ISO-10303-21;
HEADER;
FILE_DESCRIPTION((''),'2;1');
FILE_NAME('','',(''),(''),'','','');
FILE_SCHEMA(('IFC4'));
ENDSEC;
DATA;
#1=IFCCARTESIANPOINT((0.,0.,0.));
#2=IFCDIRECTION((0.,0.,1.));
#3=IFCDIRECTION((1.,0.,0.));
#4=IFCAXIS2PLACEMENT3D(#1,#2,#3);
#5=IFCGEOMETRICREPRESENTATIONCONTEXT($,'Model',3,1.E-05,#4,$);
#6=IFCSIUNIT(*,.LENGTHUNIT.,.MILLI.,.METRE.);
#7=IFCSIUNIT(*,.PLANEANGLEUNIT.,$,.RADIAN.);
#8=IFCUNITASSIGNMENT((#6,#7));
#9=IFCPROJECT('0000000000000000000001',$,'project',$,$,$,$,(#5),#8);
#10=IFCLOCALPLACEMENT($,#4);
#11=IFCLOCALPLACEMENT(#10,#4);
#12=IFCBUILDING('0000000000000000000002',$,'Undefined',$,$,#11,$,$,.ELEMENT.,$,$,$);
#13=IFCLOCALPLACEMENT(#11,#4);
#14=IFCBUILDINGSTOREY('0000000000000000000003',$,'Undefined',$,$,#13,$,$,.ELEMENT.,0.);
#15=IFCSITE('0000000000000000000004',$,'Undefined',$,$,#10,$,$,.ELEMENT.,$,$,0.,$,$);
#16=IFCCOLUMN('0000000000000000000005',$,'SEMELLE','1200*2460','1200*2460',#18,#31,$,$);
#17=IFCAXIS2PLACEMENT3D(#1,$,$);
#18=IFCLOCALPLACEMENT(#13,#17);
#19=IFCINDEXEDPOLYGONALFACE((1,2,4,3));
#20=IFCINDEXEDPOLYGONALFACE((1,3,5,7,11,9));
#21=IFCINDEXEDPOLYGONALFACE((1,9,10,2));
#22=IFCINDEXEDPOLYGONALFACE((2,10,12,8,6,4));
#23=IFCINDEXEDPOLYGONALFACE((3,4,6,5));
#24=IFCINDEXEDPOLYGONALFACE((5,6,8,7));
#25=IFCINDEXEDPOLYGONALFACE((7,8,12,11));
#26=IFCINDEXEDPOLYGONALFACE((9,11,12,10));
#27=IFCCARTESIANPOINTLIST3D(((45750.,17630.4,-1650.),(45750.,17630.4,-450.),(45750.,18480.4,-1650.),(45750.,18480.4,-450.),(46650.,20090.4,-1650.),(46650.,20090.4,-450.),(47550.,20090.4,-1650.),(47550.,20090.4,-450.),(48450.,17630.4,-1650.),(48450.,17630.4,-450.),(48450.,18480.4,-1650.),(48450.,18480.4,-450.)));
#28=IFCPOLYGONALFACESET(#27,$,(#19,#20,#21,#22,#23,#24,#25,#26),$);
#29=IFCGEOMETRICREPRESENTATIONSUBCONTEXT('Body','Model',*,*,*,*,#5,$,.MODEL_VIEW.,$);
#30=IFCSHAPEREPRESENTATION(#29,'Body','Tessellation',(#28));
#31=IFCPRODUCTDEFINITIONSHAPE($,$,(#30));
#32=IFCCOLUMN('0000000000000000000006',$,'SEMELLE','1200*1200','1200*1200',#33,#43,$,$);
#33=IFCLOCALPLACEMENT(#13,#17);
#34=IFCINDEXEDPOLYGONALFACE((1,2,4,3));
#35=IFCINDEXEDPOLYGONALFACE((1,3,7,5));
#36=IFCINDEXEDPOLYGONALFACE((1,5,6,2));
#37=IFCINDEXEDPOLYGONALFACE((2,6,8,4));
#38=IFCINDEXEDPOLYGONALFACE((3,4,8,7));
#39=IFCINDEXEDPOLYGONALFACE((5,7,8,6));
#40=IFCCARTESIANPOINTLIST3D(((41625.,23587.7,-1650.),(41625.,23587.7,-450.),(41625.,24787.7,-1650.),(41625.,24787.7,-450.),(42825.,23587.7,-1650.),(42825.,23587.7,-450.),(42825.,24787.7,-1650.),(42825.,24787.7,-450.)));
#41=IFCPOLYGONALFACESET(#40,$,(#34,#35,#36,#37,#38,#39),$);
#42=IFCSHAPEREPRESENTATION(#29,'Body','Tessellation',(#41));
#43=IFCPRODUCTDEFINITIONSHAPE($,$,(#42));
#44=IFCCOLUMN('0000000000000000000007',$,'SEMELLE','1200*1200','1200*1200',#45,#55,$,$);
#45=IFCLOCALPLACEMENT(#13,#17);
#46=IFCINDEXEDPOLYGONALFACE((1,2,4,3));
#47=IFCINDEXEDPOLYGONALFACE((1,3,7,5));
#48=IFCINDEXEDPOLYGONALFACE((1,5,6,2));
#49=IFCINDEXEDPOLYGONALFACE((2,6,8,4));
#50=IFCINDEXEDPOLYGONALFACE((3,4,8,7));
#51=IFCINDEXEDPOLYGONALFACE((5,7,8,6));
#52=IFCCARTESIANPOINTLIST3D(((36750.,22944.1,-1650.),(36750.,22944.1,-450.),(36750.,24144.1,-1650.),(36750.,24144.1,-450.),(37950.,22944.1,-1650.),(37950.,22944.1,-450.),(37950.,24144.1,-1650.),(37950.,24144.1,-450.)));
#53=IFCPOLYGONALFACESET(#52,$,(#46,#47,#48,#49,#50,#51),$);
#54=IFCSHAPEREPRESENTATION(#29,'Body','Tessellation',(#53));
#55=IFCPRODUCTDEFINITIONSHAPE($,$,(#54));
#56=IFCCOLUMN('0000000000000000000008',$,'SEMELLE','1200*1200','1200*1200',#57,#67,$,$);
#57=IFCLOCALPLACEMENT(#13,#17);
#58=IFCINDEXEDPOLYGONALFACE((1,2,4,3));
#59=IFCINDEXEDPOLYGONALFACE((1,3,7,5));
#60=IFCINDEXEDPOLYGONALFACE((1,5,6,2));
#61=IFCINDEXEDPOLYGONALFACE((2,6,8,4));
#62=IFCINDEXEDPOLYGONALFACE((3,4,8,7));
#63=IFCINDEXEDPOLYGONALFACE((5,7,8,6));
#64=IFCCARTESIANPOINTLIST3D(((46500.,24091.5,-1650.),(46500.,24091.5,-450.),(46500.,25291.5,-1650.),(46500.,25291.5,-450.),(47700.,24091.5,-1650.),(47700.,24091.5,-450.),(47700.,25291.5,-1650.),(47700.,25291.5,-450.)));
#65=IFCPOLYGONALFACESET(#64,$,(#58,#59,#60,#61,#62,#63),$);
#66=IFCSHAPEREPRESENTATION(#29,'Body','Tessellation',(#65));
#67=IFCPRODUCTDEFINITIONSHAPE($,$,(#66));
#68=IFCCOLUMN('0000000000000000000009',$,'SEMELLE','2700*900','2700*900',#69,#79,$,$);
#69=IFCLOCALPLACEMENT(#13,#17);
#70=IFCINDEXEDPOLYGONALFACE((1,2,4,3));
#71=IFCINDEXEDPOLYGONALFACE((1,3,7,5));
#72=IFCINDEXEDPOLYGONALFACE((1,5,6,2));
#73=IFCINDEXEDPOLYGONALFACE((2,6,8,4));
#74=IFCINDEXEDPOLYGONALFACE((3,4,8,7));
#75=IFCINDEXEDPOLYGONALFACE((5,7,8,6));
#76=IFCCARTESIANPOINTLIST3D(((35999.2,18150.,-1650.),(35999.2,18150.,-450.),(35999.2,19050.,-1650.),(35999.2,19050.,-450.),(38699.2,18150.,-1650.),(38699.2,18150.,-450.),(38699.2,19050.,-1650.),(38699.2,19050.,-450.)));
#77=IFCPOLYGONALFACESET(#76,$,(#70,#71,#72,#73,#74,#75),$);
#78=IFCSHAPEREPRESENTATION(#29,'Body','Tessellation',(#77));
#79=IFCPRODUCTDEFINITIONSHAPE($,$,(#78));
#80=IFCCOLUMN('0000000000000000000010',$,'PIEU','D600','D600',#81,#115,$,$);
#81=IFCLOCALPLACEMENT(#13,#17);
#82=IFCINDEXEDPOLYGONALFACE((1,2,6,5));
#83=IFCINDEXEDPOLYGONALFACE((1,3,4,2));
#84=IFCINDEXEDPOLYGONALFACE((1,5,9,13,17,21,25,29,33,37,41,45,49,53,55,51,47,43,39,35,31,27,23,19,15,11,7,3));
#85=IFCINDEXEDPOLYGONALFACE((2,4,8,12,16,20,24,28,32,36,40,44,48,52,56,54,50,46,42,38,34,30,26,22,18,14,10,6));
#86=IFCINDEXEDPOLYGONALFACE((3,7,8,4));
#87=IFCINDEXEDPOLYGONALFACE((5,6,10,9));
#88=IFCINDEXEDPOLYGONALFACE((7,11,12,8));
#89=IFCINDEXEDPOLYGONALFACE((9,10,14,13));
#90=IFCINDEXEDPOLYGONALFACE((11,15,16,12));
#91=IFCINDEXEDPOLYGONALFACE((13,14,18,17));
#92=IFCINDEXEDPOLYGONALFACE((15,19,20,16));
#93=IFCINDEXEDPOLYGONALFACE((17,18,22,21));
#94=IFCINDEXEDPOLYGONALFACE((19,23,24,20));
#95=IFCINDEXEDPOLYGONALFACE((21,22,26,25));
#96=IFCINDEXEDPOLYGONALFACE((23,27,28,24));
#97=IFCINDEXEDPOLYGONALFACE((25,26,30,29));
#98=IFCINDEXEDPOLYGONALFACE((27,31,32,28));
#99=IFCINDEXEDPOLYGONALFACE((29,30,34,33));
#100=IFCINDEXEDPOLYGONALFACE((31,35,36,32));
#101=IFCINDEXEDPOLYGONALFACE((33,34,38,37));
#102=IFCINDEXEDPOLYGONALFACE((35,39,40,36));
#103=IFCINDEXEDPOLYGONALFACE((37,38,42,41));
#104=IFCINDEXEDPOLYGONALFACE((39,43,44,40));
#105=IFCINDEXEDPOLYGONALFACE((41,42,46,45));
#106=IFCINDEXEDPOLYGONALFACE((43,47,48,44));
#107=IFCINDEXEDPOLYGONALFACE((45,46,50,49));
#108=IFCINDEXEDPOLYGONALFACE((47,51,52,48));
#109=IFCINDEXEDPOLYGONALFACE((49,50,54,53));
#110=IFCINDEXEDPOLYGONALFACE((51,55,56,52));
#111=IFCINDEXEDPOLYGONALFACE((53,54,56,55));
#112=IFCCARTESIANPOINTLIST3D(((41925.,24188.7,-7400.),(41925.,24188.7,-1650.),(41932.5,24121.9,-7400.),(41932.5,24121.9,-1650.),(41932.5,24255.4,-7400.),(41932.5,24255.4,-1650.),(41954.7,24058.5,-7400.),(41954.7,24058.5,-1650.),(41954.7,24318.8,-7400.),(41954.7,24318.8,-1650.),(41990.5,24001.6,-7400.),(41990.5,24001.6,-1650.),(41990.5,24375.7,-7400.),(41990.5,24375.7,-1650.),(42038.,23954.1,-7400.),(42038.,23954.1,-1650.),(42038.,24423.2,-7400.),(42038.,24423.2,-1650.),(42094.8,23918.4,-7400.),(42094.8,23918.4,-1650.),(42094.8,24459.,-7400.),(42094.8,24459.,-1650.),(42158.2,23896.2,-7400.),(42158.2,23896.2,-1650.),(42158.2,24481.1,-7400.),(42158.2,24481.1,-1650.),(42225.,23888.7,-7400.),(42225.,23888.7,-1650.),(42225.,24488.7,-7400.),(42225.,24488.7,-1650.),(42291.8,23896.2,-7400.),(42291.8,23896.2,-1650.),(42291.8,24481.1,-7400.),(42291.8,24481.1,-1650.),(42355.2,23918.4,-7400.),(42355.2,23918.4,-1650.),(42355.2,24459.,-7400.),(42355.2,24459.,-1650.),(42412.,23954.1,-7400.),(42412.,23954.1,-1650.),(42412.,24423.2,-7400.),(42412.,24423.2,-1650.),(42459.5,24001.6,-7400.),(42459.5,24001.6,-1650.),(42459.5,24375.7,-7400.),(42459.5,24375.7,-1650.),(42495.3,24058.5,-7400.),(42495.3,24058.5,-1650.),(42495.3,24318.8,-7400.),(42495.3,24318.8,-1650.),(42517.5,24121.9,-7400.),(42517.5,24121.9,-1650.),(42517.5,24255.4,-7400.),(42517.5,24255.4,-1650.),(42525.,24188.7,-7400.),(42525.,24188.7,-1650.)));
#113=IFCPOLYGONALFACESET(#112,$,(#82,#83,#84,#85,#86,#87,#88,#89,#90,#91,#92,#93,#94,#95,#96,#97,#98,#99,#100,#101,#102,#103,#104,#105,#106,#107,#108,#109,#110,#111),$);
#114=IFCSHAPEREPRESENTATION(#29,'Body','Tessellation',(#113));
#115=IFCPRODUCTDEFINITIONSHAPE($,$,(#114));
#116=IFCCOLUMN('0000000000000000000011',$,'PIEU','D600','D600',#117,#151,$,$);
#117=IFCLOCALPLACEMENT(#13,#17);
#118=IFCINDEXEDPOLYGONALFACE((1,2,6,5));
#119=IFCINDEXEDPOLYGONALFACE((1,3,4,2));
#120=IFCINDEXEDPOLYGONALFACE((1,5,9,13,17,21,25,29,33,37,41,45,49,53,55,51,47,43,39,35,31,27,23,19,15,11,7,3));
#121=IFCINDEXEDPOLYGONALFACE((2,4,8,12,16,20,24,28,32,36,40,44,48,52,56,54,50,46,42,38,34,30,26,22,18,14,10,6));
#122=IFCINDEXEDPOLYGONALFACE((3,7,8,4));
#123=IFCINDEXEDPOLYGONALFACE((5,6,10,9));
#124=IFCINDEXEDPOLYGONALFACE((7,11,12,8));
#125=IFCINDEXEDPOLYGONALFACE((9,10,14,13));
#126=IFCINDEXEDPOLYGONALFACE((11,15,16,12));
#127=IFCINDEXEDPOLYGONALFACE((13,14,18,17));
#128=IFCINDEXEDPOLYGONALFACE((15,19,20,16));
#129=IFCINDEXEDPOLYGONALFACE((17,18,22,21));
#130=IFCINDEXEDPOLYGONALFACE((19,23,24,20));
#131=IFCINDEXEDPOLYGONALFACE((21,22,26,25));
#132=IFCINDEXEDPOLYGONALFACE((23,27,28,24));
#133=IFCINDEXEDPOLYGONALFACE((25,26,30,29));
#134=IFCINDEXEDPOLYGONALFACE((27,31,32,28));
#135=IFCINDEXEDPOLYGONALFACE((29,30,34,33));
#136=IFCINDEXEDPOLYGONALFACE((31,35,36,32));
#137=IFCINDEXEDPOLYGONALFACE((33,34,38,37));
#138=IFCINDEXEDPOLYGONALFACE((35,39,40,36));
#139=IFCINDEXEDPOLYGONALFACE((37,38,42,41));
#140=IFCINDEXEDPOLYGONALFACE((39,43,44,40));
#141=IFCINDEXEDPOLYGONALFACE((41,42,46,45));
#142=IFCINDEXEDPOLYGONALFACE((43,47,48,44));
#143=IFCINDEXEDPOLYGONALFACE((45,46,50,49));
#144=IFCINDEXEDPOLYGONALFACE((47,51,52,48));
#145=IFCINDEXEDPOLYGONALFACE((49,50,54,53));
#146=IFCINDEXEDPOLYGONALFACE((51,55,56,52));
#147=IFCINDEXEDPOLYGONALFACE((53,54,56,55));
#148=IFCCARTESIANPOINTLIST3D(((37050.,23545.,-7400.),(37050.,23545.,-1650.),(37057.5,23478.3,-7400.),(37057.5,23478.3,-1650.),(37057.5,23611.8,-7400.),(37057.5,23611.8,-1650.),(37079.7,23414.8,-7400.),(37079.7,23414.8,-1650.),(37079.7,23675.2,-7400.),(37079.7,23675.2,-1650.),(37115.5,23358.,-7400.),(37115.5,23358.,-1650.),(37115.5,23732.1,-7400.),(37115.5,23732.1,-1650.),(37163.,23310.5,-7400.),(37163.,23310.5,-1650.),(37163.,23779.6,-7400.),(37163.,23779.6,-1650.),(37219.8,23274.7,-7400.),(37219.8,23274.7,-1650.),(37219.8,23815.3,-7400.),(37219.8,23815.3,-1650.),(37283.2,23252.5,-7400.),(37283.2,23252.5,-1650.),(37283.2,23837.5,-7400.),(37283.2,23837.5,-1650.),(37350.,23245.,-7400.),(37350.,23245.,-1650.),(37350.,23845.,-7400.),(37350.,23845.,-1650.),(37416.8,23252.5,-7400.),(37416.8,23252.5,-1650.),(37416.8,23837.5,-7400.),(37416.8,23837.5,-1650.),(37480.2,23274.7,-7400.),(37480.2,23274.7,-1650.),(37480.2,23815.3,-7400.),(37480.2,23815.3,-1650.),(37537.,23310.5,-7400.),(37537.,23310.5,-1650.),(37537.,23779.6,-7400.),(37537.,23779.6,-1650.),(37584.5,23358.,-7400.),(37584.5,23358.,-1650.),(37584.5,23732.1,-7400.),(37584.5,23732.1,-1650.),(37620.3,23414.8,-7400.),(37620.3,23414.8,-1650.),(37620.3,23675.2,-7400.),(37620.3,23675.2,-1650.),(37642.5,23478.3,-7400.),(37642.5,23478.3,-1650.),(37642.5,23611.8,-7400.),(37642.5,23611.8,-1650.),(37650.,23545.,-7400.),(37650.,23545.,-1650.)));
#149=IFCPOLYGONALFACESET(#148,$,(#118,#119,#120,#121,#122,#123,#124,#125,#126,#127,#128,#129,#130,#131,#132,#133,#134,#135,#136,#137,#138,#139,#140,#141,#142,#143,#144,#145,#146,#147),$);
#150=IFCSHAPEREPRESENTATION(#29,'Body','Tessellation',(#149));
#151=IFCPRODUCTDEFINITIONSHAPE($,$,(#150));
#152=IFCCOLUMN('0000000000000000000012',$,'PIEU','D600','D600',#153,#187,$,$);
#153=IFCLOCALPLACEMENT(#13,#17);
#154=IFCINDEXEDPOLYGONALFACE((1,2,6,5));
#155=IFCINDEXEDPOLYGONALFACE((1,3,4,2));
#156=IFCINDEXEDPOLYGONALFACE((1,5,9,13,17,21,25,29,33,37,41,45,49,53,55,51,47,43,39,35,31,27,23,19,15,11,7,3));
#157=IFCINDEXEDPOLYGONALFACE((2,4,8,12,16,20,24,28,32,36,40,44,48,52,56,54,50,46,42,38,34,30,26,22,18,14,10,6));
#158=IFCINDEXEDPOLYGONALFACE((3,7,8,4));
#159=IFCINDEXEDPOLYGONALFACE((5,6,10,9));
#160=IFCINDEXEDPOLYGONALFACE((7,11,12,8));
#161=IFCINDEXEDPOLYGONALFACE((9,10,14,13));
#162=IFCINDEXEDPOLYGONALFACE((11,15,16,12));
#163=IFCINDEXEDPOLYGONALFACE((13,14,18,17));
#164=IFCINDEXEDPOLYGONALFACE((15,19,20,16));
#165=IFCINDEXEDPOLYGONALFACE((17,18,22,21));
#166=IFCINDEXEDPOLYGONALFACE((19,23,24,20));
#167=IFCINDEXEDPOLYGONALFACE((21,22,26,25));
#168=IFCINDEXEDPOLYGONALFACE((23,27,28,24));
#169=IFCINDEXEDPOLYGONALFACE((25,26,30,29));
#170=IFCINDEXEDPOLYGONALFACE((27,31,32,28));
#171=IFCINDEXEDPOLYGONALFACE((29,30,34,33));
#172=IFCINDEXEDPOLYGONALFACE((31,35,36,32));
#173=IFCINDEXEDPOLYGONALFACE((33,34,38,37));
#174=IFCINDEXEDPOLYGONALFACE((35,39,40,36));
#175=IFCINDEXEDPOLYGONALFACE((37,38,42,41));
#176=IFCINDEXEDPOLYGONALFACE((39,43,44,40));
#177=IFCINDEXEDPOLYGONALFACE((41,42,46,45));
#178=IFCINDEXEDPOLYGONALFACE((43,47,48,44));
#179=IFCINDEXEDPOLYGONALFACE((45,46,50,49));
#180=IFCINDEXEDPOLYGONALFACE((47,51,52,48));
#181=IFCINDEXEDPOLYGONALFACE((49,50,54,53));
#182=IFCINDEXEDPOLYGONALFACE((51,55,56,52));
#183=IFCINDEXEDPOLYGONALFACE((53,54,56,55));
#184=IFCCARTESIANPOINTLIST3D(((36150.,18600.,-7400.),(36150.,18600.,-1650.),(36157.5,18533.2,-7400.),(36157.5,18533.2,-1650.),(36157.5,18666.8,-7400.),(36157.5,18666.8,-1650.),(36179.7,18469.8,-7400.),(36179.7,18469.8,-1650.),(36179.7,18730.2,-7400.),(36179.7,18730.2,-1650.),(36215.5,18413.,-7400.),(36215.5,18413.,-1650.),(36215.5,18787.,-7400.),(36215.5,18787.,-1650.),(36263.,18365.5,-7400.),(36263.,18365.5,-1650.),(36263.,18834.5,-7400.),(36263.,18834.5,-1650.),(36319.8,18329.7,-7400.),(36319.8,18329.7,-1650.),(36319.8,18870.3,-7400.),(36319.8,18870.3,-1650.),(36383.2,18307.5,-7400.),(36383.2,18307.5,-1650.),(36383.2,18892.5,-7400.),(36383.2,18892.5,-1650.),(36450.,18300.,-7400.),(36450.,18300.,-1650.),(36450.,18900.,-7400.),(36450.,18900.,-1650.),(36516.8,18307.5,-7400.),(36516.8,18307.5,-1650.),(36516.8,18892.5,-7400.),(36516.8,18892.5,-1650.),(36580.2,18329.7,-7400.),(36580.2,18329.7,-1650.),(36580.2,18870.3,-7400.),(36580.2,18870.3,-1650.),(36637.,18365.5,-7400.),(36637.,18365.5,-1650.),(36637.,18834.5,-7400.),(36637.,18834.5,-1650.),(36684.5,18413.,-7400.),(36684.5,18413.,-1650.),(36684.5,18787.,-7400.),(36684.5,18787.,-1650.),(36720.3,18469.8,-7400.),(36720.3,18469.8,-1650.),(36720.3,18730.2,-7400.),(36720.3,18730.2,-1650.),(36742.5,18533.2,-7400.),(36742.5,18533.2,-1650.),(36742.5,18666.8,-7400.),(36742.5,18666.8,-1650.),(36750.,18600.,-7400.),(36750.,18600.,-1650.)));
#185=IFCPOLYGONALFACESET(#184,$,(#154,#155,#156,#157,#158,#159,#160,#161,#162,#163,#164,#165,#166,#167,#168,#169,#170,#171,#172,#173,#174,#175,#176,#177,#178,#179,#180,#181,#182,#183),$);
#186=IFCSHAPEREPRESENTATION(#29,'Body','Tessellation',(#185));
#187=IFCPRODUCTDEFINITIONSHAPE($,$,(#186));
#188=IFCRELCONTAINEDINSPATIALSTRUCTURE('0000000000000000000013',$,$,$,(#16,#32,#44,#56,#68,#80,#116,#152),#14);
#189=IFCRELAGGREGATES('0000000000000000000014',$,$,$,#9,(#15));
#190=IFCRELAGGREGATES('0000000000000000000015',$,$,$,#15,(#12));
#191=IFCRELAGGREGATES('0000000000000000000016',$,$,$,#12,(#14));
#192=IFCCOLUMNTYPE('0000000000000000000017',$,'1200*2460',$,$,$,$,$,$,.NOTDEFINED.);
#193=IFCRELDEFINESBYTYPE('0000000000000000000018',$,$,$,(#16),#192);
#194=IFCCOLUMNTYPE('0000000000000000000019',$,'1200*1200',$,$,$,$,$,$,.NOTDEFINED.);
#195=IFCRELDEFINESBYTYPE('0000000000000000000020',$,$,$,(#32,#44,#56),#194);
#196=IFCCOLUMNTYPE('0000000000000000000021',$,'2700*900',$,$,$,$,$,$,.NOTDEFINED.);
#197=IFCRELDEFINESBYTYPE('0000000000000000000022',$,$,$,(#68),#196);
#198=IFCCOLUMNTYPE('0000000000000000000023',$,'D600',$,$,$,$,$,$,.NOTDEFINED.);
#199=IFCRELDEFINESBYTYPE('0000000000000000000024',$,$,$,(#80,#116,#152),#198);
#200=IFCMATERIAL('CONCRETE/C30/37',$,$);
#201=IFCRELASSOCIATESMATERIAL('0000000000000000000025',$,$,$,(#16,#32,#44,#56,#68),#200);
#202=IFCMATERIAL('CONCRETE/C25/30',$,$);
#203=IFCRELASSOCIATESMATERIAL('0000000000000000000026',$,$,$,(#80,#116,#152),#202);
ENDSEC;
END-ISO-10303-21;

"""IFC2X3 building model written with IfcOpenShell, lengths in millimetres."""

from ifc_helpers import new_model, si_unit, frame, origin_with_axes, origin_2d_with_axis, place, context, subcontext, project, spatial, polyline, rectangle, circle, outline, extrude, material, type_object, element, save


model = new_model("IFC2X3")

# Units and contexts
model_context = context("Model", 3, precision=1e-05, world=origin_with_axes())
body_context = subcontext(model_context, "Body", "Model", "MODEL_VIEW")
ifc_project = project(units=[si_unit("LENGTHUNIT", "METRE", prefix="MILLI"), si_unit("PLANEANGLEUNIT", "RADIAN")], contexts=[model_context])

# Site, building, storey
site_placement = place(None, origin_with_axes())
site = spatial("IfcSite", under=ifc_project, at=site_placement, Name="Undefined", CompositionType="ELEMENT", RefElevation=0.0)
building_placement = place(site_placement, origin_with_axes())
building = spatial("IfcBuilding", under=site, at=building_placement, Name="Undefined", CompositionType="ELEMENT")
storey_placement = place(building_placement, origin_with_axes())
storey = spatial("IfcBuildingStorey", under=building, at=storey_placement, Name="Undefined", CompositionType="ELEMENT", Elevation=0.0)

# Columns
ifc_material_1 = material(Name="CONCRETE/C30/37")
column_type_1 = type_object("IfcColumnType", Name="1200*2460", PredefinedType="NOTDEFINED")
column_1_placement = place(storey_placement, frame((46650.0, 20090.4, -1050.0), z_axis=(0.0, 0.0, 1.0), x_axis=(-0.487943, -0.872876, 0.0)))
element("IfcColumn", 1, at=column_1_placement, inside=storey, type_object=column_type_1, material=ifc_material_1, Name="SEMELLE", Description="1200*2460", ObjectType="1200*2460", context=body_context, shape_type="SweptSolid", body=[
    extrude(outline(polyline([(0.0, 0.0), (1844.5, 0.0), (2586.4, 414.8), (1269.0, 2771.5), (527.0, 2356.8), (-439.1, 785.6), (0.0, 0.0)])), frame((0.0, 0.0, -600.0), z_axis=(0.0, 0.0, 1.0), x_axis=(1.0, 0.0, 0.0)), (0.0, 0.0, 1.0), 1200.0),
])
column_type_2 = type_object("IfcColumnType", Name="1200*1200", PredefinedType="NOTDEFINED")
for number, where, z_axis, x_axis, name in (
    (2, (42225.0, 24187.7, -1650.0), (0.0, 0.0, 1.0), (1.0, 0.0, 0.0), "SEMELLE"),
    (3, (37350.0, 23544.1, -1650.0), (0.0, 0.0, 1.0), (1.0, 0.0, 0.0), "SEMELLE"),
    (4, (47100.0, 24691.5, -1650.0), (0.0, 0.0, 1.0), (1.0, 0.0, 0.0), "SEMELLE"),
):
    element("IfcColumn", number, at=place(storey_placement, frame(where, z_axis=z_axis, x_axis=x_axis)), inside=storey, type_object=column_type_2, material=ifc_material_1, Name=name, Description="1200*1200", ObjectType="1200*1200", context=body_context, shape_type="SweptSolid", body=[
        extrude(rectangle(XDim=1200.0, YDim=1200.0, at=origin_2d_with_axis()), frame((0.0, 0.0, 1200.0), z_axis=(0.0, 0.0, -1.0), x_axis=(-1.0, 0.0, 0.0)), (0.0, 0.0, 1.0), 1200.0),
    ])
column_type_3 = type_object("IfcColumnType", Name="2700*900", PredefinedType="NOTDEFINED")
column_2_placement = place(storey_placement, frame((37349.2, 18600.0, -1650.0), z_axis=(0.0, 0.0, 1.0), x_axis=(1.0, 0.0, 0.0)))
element("IfcColumn", 5, at=column_2_placement, inside=storey, type_object=column_type_3, material=ifc_material_1, Name="SEMELLE", Description="2700*900", ObjectType="2700*900", context=body_context, shape_type="SweptSolid", body=[
    extrude(rectangle(XDim=900.0, YDim=2700.0, at=origin_2d_with_axis()), frame((0.0, 0.0, 1200.0), z_axis=(0.0, 0.0, -1.0), x_axis=(0.0, -1.0, 0.0)), (0.0, 0.0, 1.0), 1200.0),
])
ifc_material_2 = material(Name="CONCRETE/C25/30")
column_type_4 = type_object("IfcColumnType", Name="D600", PredefinedType="NOTDEFINED")
for number, where, z_axis, x_axis, name in (
    (6, (42225.0, 24188.7, -7400.0), (0.0, 0.0, 1.0), (1.0, 0.0, 0.0), "PIEU"),
    (7, (37350.0, 23545.0, -7400.0), (0.0, 0.0, 1.0), (1.0, 0.0, 0.0), "PIEU"),
):
    element("IfcColumn", number, at=place(storey_placement, frame(where, z_axis=z_axis, x_axis=x_axis)), inside=storey, type_object=column_type_4, material=ifc_material_2, Name=name, Description="D600", ObjectType="D600", context=body_context, shape_type="SweptSolid", body=[
        extrude(circle(Radius=300.0, at=origin_2d_with_axis()), frame((0.0, 0.0, 5750.0), z_axis=(0.0, 0.0, -1.0), x_axis=(-1.0, 0.0, 0.0)), (0.0, 0.0, 1.0), 5750.0),
    ])
for number, where, z_axis, x_axis, name in (
    (8, (36450.0, 18600.0, -7400.0), (0.0, 0.0, 1.0), (1.0, 0.0, 0.0), "PIEU"),
):
    element("IfcColumn", number, at=place(storey_placement, frame(where, z_axis=z_axis, x_axis=x_axis)), inside=storey, type_object=column_type_4, material=ifc_material_2, Name=name, Description="D600", ObjectType="D600", context=body_context, shape_type="SweptSolid", body=[
        extrude(circle(Radius=300.0, at=origin_2d_with_axis()), frame((0.0, 0.0, 5750.0), z_axis=(0.0, 0.0, -1.0), x_axis=(0.0, 1.0, 0.0)), (0.0, 0.0, 1.0), 5750.0),
    ])

save(model, "model.ifc")
